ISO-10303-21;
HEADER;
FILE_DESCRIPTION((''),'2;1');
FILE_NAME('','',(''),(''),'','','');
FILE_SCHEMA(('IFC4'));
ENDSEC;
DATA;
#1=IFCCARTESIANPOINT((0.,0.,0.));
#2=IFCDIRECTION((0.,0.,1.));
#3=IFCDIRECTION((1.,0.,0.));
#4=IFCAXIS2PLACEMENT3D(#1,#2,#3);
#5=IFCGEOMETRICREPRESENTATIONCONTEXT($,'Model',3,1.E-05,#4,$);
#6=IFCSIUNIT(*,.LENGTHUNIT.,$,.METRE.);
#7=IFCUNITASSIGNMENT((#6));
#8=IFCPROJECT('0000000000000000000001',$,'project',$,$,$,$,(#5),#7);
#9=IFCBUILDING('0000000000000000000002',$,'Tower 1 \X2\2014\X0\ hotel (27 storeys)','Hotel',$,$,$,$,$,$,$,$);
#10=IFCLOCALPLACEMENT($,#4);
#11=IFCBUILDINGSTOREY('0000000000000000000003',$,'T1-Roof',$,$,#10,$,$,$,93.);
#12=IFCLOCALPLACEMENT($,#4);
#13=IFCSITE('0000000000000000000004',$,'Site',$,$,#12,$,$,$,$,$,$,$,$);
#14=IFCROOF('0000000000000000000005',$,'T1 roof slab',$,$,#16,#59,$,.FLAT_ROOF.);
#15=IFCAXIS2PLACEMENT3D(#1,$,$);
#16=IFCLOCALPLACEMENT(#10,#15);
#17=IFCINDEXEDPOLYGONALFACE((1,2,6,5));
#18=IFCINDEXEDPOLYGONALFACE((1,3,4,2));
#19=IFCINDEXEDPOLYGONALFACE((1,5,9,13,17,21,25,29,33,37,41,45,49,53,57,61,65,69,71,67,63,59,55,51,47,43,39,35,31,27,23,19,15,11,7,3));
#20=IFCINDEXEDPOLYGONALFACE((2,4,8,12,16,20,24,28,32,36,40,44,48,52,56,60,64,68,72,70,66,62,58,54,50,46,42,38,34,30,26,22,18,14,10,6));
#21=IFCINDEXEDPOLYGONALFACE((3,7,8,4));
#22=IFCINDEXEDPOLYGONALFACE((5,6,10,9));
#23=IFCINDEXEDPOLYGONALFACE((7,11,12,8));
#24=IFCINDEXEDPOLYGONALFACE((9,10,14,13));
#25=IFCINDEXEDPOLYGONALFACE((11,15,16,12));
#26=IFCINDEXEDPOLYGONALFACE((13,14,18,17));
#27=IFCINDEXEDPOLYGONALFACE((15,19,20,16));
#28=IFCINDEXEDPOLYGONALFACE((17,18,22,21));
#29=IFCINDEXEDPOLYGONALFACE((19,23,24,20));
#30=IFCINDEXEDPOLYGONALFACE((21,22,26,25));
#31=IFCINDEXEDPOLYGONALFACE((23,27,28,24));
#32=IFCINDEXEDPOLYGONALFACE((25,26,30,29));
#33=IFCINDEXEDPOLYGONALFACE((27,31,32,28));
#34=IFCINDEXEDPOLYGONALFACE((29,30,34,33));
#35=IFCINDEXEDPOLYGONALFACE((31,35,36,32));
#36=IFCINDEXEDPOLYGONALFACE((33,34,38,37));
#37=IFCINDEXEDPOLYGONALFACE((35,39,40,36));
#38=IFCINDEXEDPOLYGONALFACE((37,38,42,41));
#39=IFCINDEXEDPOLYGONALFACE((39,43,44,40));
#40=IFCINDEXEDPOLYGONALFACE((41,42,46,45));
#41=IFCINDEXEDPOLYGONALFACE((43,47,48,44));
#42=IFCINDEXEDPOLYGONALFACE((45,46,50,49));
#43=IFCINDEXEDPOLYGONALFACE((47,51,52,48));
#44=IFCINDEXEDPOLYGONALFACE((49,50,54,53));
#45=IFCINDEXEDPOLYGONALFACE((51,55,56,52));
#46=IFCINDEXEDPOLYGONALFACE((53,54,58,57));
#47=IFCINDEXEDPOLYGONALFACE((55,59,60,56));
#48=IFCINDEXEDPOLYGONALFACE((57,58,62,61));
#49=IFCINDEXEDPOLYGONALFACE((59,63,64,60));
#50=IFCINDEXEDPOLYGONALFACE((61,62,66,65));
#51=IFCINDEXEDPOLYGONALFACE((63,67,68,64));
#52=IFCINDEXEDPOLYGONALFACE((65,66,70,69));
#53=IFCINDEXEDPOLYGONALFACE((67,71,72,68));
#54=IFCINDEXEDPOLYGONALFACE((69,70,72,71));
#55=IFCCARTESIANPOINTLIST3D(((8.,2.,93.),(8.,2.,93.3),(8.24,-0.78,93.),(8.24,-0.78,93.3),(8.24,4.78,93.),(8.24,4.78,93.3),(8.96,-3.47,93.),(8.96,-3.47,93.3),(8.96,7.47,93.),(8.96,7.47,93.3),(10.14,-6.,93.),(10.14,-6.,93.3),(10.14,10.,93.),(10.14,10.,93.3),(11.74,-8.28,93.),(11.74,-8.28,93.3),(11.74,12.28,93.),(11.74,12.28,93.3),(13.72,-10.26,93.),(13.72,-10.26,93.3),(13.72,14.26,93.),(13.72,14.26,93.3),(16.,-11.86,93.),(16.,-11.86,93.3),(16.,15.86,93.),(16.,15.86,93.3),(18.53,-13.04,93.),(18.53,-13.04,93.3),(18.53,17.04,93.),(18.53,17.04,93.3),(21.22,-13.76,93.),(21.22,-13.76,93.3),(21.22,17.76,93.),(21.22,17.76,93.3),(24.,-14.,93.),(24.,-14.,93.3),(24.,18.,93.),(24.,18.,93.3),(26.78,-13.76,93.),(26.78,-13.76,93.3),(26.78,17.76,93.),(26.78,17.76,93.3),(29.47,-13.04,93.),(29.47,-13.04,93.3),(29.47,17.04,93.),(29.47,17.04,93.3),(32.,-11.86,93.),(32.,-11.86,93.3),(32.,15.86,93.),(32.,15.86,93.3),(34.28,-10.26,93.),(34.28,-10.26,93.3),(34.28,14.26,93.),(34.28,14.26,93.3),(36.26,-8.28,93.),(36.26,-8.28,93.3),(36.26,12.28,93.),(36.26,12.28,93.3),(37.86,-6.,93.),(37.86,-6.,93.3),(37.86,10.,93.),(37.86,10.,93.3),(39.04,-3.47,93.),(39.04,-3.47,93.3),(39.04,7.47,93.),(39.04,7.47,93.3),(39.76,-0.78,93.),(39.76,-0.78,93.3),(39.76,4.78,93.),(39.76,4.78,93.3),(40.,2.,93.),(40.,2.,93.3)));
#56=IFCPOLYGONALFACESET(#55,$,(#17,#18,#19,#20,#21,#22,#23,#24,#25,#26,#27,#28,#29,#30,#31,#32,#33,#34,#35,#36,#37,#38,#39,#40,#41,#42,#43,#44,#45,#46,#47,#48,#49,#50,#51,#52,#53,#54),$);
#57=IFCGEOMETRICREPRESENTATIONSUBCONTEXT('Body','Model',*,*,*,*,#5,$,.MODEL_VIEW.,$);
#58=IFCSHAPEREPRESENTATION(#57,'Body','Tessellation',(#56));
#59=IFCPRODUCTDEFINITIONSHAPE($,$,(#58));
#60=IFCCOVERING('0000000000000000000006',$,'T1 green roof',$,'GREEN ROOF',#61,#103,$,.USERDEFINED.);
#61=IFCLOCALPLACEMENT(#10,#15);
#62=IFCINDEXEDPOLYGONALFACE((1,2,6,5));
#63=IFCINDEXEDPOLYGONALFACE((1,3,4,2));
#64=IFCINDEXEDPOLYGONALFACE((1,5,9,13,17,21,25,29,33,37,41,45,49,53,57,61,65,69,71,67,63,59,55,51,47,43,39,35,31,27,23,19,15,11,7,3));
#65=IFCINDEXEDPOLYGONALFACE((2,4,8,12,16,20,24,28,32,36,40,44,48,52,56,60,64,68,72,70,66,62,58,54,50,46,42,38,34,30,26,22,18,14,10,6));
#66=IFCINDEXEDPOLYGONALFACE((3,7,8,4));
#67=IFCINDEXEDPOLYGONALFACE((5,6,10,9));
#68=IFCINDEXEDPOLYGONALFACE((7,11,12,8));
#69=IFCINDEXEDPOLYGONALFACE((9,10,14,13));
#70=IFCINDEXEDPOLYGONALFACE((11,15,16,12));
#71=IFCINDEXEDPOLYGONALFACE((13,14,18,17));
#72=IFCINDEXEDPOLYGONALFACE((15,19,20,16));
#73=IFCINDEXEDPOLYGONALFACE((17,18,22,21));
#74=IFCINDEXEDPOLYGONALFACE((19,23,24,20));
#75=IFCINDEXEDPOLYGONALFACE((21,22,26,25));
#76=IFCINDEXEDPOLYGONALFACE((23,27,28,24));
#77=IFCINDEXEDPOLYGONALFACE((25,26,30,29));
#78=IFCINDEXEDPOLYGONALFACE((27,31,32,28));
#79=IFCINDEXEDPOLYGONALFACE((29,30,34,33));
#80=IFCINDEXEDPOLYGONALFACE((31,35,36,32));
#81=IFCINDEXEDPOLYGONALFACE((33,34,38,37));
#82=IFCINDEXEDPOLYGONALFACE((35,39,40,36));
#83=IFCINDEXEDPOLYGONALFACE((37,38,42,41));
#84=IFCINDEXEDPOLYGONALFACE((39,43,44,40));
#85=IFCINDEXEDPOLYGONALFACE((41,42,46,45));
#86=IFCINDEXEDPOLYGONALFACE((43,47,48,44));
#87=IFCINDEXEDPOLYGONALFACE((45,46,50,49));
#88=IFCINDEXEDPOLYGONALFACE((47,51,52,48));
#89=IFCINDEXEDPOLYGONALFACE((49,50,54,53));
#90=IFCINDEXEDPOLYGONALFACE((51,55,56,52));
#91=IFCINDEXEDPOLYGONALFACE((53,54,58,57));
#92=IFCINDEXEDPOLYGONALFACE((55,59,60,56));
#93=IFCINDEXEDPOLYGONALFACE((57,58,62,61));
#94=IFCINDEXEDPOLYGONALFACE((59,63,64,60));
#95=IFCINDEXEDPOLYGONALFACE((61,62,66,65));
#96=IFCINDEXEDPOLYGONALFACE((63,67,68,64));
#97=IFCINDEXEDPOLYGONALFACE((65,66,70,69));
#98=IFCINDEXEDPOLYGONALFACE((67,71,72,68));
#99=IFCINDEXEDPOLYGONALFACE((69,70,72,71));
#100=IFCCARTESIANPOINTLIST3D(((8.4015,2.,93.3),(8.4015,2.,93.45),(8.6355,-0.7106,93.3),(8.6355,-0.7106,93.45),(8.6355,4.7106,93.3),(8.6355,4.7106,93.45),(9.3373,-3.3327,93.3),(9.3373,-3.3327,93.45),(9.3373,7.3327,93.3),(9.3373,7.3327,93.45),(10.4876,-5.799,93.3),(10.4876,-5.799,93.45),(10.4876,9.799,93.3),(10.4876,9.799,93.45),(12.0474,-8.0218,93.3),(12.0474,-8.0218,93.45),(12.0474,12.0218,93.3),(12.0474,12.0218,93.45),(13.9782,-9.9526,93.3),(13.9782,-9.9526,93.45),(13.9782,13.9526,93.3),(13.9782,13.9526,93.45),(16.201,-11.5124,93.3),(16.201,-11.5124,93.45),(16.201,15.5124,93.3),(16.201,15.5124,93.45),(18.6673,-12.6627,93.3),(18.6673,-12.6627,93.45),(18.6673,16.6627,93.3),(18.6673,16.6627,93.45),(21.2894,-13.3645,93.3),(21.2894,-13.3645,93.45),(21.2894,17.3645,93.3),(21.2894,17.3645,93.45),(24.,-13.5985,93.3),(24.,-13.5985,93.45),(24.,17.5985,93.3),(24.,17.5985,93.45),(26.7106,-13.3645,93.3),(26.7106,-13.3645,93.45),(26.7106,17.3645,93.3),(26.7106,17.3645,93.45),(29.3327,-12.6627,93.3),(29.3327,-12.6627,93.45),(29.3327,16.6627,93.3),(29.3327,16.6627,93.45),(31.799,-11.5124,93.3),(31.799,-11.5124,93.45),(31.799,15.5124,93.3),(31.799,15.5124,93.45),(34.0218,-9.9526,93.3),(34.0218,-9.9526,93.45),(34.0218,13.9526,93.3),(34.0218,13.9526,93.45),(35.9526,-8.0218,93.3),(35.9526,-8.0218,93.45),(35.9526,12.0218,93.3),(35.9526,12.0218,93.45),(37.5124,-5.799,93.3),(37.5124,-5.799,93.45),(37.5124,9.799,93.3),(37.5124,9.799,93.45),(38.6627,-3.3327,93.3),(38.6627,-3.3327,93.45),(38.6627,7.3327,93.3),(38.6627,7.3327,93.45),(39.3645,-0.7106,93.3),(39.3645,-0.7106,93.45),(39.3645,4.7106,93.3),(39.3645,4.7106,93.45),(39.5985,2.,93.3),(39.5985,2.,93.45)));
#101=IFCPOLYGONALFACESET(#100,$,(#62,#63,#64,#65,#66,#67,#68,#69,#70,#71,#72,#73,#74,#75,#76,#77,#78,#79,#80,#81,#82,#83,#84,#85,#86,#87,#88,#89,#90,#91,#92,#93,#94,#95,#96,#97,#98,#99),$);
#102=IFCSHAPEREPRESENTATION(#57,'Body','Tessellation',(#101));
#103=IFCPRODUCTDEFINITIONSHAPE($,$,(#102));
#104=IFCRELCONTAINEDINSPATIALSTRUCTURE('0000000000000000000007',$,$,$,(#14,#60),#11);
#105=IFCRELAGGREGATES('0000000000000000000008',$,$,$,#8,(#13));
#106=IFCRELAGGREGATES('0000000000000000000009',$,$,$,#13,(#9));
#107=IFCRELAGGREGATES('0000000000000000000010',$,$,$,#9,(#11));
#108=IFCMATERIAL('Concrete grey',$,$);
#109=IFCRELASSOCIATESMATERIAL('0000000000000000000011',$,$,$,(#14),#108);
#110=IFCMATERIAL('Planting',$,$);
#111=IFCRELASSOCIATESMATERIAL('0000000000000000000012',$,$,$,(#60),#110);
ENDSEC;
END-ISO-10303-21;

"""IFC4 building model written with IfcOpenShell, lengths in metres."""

from ifc_helpers import new_model, si_unit, frame, origin_with_axes, place, context, subcontext, project, spatial, polyline, outline, extrude, material, element, save


model = new_model("IFC4")

# Units and contexts
model_context = context("Model", 3, precision=1e-05, world=origin_with_axes())
body_context = subcontext(model_context, "Body", "Model", "MODEL_VIEW")
ifc_project = project(units=[si_unit("LENGTHUNIT", "METRE")], contexts=[model_context])

# Site, building, storey
site_placement = place(None, origin_with_axes())
site = spatial("IfcSite", under=ifc_project, at=site_placement, Name="Site")
building = spatial("IfcBuilding", under=site, Name="Tower 1 — hotel (27 storeys)", Description="Hotel")
storey_placement = place(None, origin_with_axes())
storey = spatial("IfcBuildingStorey", under=building, at=storey_placement, Name="T1-Roof", Elevation=93.0)

# Roof
ifc_material_1 = material(Name="Concrete grey")
roof_placement = place(storey_placement, origin_with_axes())
element("IfcRoof", 1, at=roof_placement, inside=storey, material=ifc_material_1, Name="T1 roof slab", PredefinedType="FLAT_ROOF", context=body_context, shape_type="SweptSolid", body=[
    extrude(outline(polyline([(40.0, 2.0), (39.76, 4.78), (39.04, 7.47), (37.86, 10.0), (36.26, 12.28), (34.28, 14.26), (32.0, 15.86), (29.47, 17.04), (26.78, 17.76), (24.0, 18.0), (21.22, 17.76), (18.53, 17.04), (16.0, 15.86), (13.72, 14.26), (11.74, 12.28), (10.14, 10.0), (8.96, 7.47), (8.24, 4.78), (8.0, 2.0), (8.24, -0.78), (8.96, -3.47), (10.14, -6.0), (11.74, -8.28), (13.72, -10.26), (16.0, -11.86), (18.53, -13.04), (21.22, -13.76), (24.0, -14.0), (26.78, -13.76), (29.47, -13.04), (32.0, -11.86), (34.28, -10.26), (36.26, -8.28), (37.86, -6.0), (39.04, -3.47), (39.76, -0.78), (40.0, 2.0)])), frame((0.0, 0.0, 93.0), z_axis=(0.0, 0.0, 1.0), x_axis=(1.0, 0.0, 0.0)), (0.0, 0.0, 1.0), 0.3),
])

# Covering
ifc_material_2 = material(Name="Planting")
covering_placement = place(storey_placement, origin_with_axes())
element("IfcCovering", 2, at=covering_placement, inside=storey, material=ifc_material_2, Name="T1 green roof", ObjectType="GREEN ROOF", PredefinedType="USERDEFINED", context=body_context, shape_type="SweptSolid", body=[
    extrude(outline(polyline([(39.5985, 2.0), (39.3645, 4.7106), (38.6627, 7.3327), (37.5124, 9.799), (35.9526, 12.0218), (34.0218, 13.9526), (31.799, 15.5124), (29.3327, 16.6627), (26.7106, 17.3645), (24.0, 17.5985), (21.2894, 17.3645), (18.6673, 16.6627), (16.201, 15.5124), (13.9782, 13.9526), (12.0474, 12.0218), (10.4876, 9.799), (9.3373, 7.3327), (8.6355, 4.7106), (8.4015, 2.0), (8.6355, -0.7106), (9.3373, -3.3327), (10.4876, -5.799), (12.0474, -8.0218), (13.9782, -9.9526), (16.201, -11.5124), (18.6673, -12.6627), (21.2894, -13.3645), (24.0, -13.5985), (26.7106, -13.3645), (29.3327, -12.6627), (31.799, -11.5124), (34.0218, -9.9526), (35.9526, -8.0218), (37.5124, -5.799), (38.6627, -3.3327), (39.3645, -0.7106), (39.5985, 2.0)])), frame((0.0, 0.0, 93.3), z_axis=(0.0, 0.0, 1.0), x_axis=(1.0, 0.0, 0.0)), (0.0, 0.0, 1.0), 0.15),
])

save(model, "model.ifc")
